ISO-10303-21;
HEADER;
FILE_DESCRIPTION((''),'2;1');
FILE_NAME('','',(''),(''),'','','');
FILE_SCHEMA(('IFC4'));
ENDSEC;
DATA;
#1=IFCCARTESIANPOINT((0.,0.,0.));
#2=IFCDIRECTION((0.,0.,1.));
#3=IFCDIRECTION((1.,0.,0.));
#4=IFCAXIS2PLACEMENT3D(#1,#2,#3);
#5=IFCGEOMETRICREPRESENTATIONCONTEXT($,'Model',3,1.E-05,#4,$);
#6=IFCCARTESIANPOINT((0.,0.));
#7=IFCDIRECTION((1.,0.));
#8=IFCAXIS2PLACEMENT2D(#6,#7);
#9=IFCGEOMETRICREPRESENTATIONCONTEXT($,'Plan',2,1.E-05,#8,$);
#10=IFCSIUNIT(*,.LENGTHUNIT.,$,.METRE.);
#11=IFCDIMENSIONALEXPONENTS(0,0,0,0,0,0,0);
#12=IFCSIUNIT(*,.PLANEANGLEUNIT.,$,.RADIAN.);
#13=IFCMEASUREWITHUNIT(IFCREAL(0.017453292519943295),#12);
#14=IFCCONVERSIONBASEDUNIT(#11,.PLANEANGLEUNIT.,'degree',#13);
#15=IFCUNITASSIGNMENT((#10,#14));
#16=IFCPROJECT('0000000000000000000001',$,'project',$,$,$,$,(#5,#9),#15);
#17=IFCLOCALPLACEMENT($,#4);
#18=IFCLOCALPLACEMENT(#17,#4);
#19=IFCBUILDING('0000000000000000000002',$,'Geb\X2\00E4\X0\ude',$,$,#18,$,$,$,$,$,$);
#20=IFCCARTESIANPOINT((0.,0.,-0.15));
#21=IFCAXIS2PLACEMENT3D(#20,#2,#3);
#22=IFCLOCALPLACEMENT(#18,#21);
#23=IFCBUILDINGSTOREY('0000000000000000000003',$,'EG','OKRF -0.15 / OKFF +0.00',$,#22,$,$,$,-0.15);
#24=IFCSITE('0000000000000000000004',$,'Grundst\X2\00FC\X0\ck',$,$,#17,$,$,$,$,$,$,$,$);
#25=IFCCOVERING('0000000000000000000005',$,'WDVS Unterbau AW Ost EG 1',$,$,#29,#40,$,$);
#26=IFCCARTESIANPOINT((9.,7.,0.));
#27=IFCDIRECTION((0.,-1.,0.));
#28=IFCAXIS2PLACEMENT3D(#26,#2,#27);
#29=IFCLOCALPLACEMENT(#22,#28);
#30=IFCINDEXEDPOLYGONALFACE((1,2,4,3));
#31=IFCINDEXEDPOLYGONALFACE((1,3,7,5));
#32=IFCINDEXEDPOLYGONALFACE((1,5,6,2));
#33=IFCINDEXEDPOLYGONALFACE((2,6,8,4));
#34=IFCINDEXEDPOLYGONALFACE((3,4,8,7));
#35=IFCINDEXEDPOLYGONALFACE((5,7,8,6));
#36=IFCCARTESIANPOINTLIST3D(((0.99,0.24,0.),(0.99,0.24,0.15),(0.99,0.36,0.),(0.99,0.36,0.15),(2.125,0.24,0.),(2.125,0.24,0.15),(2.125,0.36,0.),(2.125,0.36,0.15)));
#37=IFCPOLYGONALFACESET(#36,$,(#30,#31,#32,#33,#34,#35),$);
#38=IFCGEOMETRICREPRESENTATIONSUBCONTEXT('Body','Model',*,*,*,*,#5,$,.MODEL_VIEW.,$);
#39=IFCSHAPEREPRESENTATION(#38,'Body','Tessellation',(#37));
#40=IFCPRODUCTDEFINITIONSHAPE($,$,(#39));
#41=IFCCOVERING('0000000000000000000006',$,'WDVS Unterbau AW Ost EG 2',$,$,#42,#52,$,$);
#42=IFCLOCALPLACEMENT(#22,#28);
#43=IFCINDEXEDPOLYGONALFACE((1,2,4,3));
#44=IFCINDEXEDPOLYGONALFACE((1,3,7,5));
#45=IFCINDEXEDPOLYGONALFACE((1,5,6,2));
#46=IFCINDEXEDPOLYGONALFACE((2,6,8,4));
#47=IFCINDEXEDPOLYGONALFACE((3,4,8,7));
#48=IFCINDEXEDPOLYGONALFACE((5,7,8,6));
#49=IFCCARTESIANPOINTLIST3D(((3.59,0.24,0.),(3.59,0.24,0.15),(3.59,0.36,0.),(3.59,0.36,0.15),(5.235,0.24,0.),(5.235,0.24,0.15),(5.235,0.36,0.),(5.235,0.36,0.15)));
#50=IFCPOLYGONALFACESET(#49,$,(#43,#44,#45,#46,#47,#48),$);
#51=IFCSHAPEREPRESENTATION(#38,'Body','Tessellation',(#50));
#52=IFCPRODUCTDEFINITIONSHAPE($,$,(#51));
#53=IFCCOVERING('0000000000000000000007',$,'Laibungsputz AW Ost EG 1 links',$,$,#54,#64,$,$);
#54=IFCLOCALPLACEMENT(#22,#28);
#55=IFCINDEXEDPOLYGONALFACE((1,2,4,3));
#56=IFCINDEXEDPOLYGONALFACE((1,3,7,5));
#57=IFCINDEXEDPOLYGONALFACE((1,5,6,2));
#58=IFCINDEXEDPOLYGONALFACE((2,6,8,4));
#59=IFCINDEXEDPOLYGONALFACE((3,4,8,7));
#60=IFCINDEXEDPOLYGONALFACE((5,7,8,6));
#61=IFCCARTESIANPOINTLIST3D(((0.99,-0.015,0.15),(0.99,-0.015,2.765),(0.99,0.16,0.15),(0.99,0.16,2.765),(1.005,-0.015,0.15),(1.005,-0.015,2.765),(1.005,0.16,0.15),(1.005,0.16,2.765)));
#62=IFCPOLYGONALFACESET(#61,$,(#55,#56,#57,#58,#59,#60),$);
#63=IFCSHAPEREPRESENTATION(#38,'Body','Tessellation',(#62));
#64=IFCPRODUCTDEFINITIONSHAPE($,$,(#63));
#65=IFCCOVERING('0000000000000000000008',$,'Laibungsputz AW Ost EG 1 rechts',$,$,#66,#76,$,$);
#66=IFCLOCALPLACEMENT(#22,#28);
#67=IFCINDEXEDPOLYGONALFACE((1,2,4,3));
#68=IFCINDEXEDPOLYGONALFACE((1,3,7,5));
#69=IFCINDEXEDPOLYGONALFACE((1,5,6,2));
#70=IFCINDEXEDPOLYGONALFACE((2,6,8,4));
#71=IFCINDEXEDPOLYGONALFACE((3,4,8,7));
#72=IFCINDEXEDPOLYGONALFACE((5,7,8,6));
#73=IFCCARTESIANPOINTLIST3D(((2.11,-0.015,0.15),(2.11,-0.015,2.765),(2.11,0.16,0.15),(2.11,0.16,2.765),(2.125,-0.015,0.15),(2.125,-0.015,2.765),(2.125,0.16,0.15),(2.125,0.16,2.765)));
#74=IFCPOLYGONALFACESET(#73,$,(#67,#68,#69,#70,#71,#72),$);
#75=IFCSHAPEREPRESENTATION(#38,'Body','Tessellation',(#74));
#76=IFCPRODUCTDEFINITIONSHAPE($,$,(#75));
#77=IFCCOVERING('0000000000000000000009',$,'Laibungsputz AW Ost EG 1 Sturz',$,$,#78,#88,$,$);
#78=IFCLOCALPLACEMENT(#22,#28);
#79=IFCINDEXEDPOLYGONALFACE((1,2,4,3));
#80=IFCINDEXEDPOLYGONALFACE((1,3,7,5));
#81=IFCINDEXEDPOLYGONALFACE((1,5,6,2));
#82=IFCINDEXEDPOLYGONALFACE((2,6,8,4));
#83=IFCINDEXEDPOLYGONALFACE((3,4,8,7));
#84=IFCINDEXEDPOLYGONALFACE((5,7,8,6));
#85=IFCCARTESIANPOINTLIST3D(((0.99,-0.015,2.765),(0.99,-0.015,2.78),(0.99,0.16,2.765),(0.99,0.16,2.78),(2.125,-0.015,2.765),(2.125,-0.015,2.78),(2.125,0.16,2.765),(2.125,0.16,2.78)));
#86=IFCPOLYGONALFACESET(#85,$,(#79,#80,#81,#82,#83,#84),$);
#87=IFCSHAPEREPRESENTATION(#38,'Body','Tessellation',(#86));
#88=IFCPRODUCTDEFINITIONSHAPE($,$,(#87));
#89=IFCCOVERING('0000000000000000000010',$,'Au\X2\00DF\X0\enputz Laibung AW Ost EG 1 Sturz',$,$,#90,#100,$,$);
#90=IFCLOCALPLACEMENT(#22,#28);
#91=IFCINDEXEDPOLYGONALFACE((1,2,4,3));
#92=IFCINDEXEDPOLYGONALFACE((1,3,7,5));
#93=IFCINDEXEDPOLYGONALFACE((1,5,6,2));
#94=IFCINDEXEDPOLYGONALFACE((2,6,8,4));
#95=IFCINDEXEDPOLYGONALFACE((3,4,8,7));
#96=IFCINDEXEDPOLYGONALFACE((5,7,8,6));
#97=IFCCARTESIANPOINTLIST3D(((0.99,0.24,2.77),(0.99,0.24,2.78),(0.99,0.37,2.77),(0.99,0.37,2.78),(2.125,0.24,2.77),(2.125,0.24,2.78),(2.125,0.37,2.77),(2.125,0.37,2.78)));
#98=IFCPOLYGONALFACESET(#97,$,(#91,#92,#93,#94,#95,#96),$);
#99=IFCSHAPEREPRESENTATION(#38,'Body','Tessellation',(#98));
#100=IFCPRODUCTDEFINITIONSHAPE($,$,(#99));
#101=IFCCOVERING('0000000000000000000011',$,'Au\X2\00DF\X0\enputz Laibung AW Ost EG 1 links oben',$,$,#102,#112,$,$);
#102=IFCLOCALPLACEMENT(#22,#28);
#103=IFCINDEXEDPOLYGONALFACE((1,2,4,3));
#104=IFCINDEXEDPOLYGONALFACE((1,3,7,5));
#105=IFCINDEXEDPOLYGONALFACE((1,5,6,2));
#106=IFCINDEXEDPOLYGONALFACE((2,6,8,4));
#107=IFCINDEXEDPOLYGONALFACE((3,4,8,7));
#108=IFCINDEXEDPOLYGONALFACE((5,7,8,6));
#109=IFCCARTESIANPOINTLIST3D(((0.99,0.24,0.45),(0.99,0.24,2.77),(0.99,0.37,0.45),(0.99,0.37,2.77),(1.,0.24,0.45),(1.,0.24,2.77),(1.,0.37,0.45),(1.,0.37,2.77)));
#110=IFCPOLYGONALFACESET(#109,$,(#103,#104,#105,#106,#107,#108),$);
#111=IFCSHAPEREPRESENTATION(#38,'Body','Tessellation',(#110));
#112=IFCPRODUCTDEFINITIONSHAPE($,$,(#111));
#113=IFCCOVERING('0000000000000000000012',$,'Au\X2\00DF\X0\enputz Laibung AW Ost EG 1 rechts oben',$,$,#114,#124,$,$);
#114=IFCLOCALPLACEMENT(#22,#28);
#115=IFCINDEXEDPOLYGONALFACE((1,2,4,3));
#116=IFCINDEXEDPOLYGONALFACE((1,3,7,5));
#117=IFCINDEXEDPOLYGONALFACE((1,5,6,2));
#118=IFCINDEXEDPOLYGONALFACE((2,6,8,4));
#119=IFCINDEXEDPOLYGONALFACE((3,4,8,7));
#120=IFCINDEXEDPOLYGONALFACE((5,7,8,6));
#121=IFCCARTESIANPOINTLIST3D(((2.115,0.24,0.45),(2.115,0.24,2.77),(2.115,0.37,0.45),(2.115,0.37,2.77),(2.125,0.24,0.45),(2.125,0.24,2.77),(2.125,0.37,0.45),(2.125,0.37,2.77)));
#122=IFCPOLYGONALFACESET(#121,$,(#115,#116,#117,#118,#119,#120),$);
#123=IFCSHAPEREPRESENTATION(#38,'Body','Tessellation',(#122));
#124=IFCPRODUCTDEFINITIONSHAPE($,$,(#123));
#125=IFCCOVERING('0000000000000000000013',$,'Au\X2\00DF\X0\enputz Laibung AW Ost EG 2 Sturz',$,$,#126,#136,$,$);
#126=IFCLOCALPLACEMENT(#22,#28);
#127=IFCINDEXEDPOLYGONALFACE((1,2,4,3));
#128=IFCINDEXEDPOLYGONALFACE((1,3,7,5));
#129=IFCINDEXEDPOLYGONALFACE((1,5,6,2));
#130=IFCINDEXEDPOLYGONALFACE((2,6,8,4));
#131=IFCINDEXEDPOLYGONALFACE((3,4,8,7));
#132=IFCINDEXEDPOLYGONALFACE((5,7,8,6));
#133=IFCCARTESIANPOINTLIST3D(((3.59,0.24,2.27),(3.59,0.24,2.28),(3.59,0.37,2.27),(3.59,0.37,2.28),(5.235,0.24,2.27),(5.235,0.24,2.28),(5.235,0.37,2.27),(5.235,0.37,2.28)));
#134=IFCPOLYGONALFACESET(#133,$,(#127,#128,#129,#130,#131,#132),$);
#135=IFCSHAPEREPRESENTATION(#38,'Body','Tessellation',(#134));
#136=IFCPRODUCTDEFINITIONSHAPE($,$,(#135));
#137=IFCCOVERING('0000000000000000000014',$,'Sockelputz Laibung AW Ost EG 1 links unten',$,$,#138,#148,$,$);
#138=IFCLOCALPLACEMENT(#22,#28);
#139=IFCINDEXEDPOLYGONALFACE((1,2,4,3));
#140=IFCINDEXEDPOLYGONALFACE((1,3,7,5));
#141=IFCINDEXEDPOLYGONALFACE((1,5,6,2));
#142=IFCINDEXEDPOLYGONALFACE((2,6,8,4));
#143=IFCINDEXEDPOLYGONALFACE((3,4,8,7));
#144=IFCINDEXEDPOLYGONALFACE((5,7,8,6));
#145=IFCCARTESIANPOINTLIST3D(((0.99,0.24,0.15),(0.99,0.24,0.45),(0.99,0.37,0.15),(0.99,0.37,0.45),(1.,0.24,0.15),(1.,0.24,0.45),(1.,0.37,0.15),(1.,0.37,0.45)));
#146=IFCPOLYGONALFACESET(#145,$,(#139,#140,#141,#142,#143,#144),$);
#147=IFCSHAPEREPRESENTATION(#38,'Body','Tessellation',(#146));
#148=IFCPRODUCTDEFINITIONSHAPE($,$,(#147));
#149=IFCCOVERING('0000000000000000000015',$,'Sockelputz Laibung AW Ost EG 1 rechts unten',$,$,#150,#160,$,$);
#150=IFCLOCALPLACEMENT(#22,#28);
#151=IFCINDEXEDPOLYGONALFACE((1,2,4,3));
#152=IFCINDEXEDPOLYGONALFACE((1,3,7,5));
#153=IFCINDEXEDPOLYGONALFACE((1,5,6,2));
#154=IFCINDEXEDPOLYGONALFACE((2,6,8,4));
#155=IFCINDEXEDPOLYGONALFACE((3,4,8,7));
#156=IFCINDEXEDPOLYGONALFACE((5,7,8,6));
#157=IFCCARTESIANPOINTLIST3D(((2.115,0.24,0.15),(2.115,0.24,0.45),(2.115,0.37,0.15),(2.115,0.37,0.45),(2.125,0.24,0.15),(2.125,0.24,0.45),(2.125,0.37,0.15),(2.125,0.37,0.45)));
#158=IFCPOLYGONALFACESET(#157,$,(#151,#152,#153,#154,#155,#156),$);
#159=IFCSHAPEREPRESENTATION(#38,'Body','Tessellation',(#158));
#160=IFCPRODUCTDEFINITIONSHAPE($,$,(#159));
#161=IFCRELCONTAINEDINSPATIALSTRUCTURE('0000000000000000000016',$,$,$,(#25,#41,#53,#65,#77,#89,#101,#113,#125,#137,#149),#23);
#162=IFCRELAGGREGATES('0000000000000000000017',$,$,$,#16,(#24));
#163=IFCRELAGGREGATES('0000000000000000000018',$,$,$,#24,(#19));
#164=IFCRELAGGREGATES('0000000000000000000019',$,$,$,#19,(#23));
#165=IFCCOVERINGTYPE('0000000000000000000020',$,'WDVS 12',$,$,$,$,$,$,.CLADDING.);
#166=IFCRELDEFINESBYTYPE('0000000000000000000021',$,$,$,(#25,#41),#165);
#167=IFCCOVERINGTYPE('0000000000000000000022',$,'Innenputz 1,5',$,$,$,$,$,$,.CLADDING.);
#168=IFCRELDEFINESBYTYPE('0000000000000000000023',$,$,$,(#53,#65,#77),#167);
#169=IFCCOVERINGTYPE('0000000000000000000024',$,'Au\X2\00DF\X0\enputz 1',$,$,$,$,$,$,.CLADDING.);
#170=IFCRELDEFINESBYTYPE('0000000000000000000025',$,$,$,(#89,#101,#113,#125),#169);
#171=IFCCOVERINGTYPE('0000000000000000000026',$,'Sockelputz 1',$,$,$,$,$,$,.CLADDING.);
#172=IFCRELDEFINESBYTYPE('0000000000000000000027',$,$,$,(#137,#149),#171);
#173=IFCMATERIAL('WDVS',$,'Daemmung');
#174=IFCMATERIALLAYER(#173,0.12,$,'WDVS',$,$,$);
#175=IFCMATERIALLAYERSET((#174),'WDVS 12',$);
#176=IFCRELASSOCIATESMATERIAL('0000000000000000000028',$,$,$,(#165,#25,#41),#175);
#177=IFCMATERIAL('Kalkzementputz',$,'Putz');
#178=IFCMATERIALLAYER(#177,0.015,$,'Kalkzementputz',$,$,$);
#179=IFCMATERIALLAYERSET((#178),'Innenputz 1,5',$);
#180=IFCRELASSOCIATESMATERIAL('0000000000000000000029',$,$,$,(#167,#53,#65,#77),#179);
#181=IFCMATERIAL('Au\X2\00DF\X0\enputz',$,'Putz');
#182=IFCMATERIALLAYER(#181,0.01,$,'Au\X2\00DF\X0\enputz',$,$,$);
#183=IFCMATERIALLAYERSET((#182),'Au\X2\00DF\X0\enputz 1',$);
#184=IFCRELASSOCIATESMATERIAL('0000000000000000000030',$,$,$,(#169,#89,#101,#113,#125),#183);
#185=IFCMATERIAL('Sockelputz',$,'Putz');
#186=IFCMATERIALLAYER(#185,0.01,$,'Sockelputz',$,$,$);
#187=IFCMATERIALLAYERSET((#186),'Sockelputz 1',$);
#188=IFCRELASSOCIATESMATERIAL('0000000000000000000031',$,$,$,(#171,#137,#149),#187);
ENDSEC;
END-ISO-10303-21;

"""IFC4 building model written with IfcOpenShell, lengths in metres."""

from ifc_helpers import new_model, entity, si_unit, converted_unit, frame, origin_with_axes, origin_2d_with_axis, place, context, subcontext, project, spatial, polyline, outline, extrude, material, layer, layer_set, layer_usage, type_object, element, save


model = new_model("IFC4")

# Units and contexts
model_context = context("Model", 3, precision=1e-05, world=origin_with_axes())
plan_context = context("Plan", 2, precision=1e-05, world=origin_2d_with_axis())
body_context_1 = subcontext(model_context, "Body", "Model", "MODEL_VIEW")
ifc_project = project(units=[si_unit("LENGTHUNIT", "METRE"), converted_unit("PLANEANGLEUNIT", "degree", entity("IfcReal", 0.017453292519943295), si_unit("PLANEANGLEUNIT", "RADIAN"), dimensions=[0, 0, 0, 0, 0, 0, 0])], contexts=[model_context, plan_context])

# Site, building, storey
site_placement = place(None, origin_with_axes())
site = spatial("IfcSite", under=ifc_project, at=site_placement, Name="Grundstück")
building_placement = place(site_placement, origin_with_axes())
building = spatial("IfcBuilding", under=site, at=building_placement, Name="Gebäude")
storey_placement = place(building_placement, frame((0.0, 0.0, -0.15), z_axis=(0.0, 0.0, 1.0), x_axis=(1.0, 0.0, 0.0)))
storey = spatial("IfcBuildingStorey", under=building, at=storey_placement, Name="EG", Description="OKRF -0.15 / OKFF +0.00", Elevation=-0.15)

# Shared definitions
ifc_material_1 = material(Name="WDVS", Category="Daemmung")

# Coverings
ifc_layer_1 = layer(ifc_material_1, 0.12, Name="WDVS")
ifc_layer_set_1 = layer_set([ifc_layer_1], Name="WDVS 12")
ifc_layer_usage_1 = layer_usage(ifc_layer_set_1, "AXIS2", "POSITIVE", 0.24)
covering_type_1 = type_object("IfcCoveringType", Name="WDVS 12", PredefinedType="CLADDING", material=ifc_layer_set_1)
covering_1_placement = place(storey_placement, frame((9.0, 7.0, 0.0), z_axis=(0.0, 0.0, 1.0), x_axis=(0.0, -1.0, 0.0)))
element("IfcCovering", 1, at=covering_1_placement, inside=storey, type_object=covering_type_1, material=ifc_layer_usage_1, Name="WDVS Unterbau AW Ost EG 1", context=body_context_1, shape_type="SweptSolid", body=[
    extrude(outline(polyline([(0.24, 0.0), (0.36, 0.0), (0.36, 0.15), (0.24, 0.15), (0.24, 0.0)])), frame((0.99, 0.0, 0.0), z_axis=(1.0, 0.0, 0.0), x_axis=(0.0, 1.0, 0.0)), (0.0, 0.0, 1.0), 1.135),
])
ifc_layer_usage_2 = layer_usage(ifc_layer_set_1, "AXIS2", "POSITIVE", 0.24)
covering_2_placement = place(storey_placement, frame((9.0, 7.0, 0.0), z_axis=(0.0, 0.0, 1.0), x_axis=(0.0, -1.0, 0.0)))
element("IfcCovering", 2, at=covering_2_placement, inside=storey, type_object=covering_type_1, material=ifc_layer_usage_2, Name="WDVS Unterbau AW Ost EG 2", context=body_context_1, shape_type="SweptSolid", body=[
    extrude(outline(polyline([(0.24, 0.0), (0.36, 0.0), (0.36, 0.15), (0.24, 0.15), (0.24, 0.0)])), frame((3.59, 0.0, 0.0), z_axis=(1.0, 0.0, 0.0), x_axis=(0.0, 1.0, 0.0)), (0.0, 0.0, 1.0), 1.645),
])
ifc_material_2 = material(Name="Kalkzementputz", Category="Putz")
ifc_layer_2 = layer(ifc_material_2, 0.015, Name="Kalkzementputz")
ifc_layer_set_2 = layer_set([ifc_layer_2], Name="Innenputz 1,5")
covering_type_2 = type_object("IfcCoveringType", Name="Innenputz 1,5", PredefinedType="CLADDING", material=ifc_layer_set_2)
ifc_layer_usage_3 = layer_usage(ifc_layer_set_2, "AXIS1", "POSITIVE", 0.99)
covering_3_placement = place(storey_placement, frame((9.0, 7.0, 0.0), z_axis=(0.0, 0.0, 1.0), x_axis=(0.0, -1.0, 0.0)))
element("IfcCovering", 3, at=covering_3_placement, inside=storey, type_object=covering_type_2, material=ifc_layer_usage_3, Name="Laibungsputz AW Ost EG 1 links", context=body_context_1, shape_type="SweptSolid", body=[
    extrude(outline(polyline([(-0.015, 0.15), (0.16, 0.15), (0.16, 2.765), (-0.015, 2.765), (-0.015, 0.15)])), frame((0.99, 0.0, 0.0), z_axis=(1.0, 0.0, 0.0), x_axis=(0.0, 1.0, 0.0)), (0.0, 0.0, 1.0), 0.015),
])
ifc_layer_usage_4 = layer_usage(ifc_layer_set_2, "AXIS1", "POSITIVE", 2.11)
covering_4_placement = place(storey_placement, frame((9.0, 7.0, 0.0), z_axis=(0.0, 0.0, 1.0), x_axis=(0.0, -1.0, 0.0)))
element("IfcCovering", 4, at=covering_4_placement, inside=storey, type_object=covering_type_2, material=ifc_layer_usage_4, Name="Laibungsputz AW Ost EG 1 rechts", context=body_context_1, shape_type="SweptSolid", body=[
    extrude(outline(polyline([(-0.015, 0.15), (0.16, 0.15), (0.16, 2.765), (-0.015, 2.765), (-0.015, 0.15)])), frame((2.11, 0.0, 0.0), z_axis=(1.0, 0.0, 0.0), x_axis=(0.0, 1.0, 0.0)), (0.0, 0.0, 1.0), 0.015),
])
ifc_layer_usage_5 = layer_usage(ifc_layer_set_2, "AXIS3", "POSITIVE", 2.765)
covering_5_placement = place(storey_placement, frame((9.0, 7.0, 0.0), z_axis=(0.0, 0.0, 1.0), x_axis=(0.0, -1.0, 0.0)))
element("IfcCovering", 5, at=covering_5_placement, inside=storey, type_object=covering_type_2, material=ifc_layer_usage_5, Name="Laibungsputz AW Ost EG 1 Sturz", context=body_context_1, shape_type="SweptSolid", body=[
    extrude(outline(polyline([(-0.015, 2.765), (0.16, 2.765), (0.16, 2.78), (-0.015, 2.78), (-0.015, 2.765)])), frame((0.99, 0.0, 0.0), z_axis=(1.0, 0.0, 0.0), x_axis=(0.0, 1.0, 0.0)), (0.0, 0.0, 1.0), 1.135),
])
ifc_material_3 = material(Name="Außenputz", Category="Putz")
ifc_layer_3 = layer(ifc_material_3, 0.01, Name="Außenputz")
ifc_layer_set_3 = layer_set([ifc_layer_3], Name="Außenputz 1")
covering_type_3 = type_object("IfcCoveringType", Name="Außenputz 1", PredefinedType="CLADDING", material=ifc_layer_set_3)
ifc_layer_usage_6 = layer_usage(ifc_layer_set_3, "AXIS3", "POSITIVE", 2.77)
covering_6_placement = place(storey_placement, frame((9.0, 7.0, 0.0), z_axis=(0.0, 0.0, 1.0), x_axis=(0.0, -1.0, 0.0)))
element("IfcCovering", 6, at=covering_6_placement, inside=storey, type_object=covering_type_3, material=ifc_layer_usage_6, Name="Außenputz Laibung AW Ost EG 1 Sturz", context=body_context_1, shape_type="SweptSolid", body=[
    extrude(outline(polyline([(0.24, 2.77), (0.37, 2.77), (0.37, 2.78), (0.24, 2.78), (0.24, 2.77)])), frame((0.99, 0.0, 0.0), z_axis=(1.0, 0.0, 0.0), x_axis=(0.0, 1.0, 0.0)), (0.0, 0.0, 1.0), 1.135),
])
ifc_layer_usage_7 = layer_usage(ifc_layer_set_3, "AXIS1", "POSITIVE", 0.99)
covering_7_placement = place(storey_placement, frame((9.0, 7.0, 0.0), z_axis=(0.0, 0.0, 1.0), x_axis=(0.0, -1.0, 0.0)))
element("IfcCovering", 7, at=covering_7_placement, inside=storey, type_object=covering_type_3, material=ifc_layer_usage_7, Name="Außenputz Laibung AW Ost EG 1 links oben", context=body_context_1, shape_type="SweptSolid", body=[
    extrude(outline(polyline([(0.24, 0.45), (0.37, 0.45), (0.37, 2.77), (0.24, 2.77), (0.24, 0.45)])), frame((0.99, 0.0, 0.0), z_axis=(1.0, 0.0, 0.0), x_axis=(0.0, 1.0, 0.0)), (0.0, 0.0, 1.0), 0.01),
])
ifc_layer_usage_8 = layer_usage(ifc_layer_set_3, "AXIS1", "POSITIVE", 2.115)
covering_8_placement = place(storey_placement, frame((9.0, 7.0, 0.0), z_axis=(0.0, 0.0, 1.0), x_axis=(0.0, -1.0, 0.0)))
element("IfcCovering", 8, at=covering_8_placement, inside=storey, type_object=covering_type_3, material=ifc_layer_usage_8, Name="Außenputz Laibung AW Ost EG 1 rechts oben", context=body_context_1, shape_type="SweptSolid", body=[
    extrude(outline(polyline([(0.24, 0.45), (0.37, 0.45), (0.37, 2.77), (0.24, 2.77), (0.24, 0.45)])), frame((2.115, 0.0, 0.0), z_axis=(1.0, 0.0, 0.0), x_axis=(0.0, 1.0, 0.0)), (0.0, 0.0, 1.0), 0.01),
])
ifc_layer_usage_9 = layer_usage(ifc_layer_set_3, "AXIS3", "POSITIVE", 2.27)
covering_9_placement = place(storey_placement, frame((9.0, 7.0, 0.0), z_axis=(0.0, 0.0, 1.0), x_axis=(0.0, -1.0, 0.0)))
element("IfcCovering", 9, at=covering_9_placement, inside=storey, type_object=covering_type_3, material=ifc_layer_usage_9, Name="Außenputz Laibung AW Ost EG 2 Sturz", context=body_context_1, shape_type="SweptSolid", body=[
    extrude(outline(polyline([(0.24, 2.27), (0.37, 2.27), (0.37, 2.28), (0.24, 2.28), (0.24, 2.27)])), frame((3.59, 0.0, 0.0), z_axis=(1.0, 0.0, 0.0), x_axis=(0.0, 1.0, 0.0)), (0.0, 0.0, 1.0), 1.645),
])
ifc_material_4 = material(Name="Sockelputz", Category="Putz")
ifc_layer_4 = layer(ifc_material_4, 0.01, Name="Sockelputz")
ifc_layer_set_4 = layer_set([ifc_layer_4], Name="Sockelputz 1")
ifc_layer_usage_10 = layer_usage(ifc_layer_set_4, "AXIS1", "POSITIVE", 0.99)
covering_type_4 = type_object("IfcCoveringType", Name="Sockelputz 1", PredefinedType="CLADDING", material=ifc_layer_set_4)
covering_10_placement = place(storey_placement, frame((9.0, 7.0, 0.0), z_axis=(0.0, 0.0, 1.0), x_axis=(0.0, -1.0, 0.0)))
element("IfcCovering", 10, at=covering_10_placement, inside=storey, type_object=covering_type_4, material=ifc_layer_usage_10, Name="Sockelputz Laibung AW Ost EG 1 links unten", context=body_context_1, shape_type="SweptSolid", body=[
    extrude(outline(polyline([(0.24, 0.15), (0.37, 0.15), (0.37, 0.45), (0.24, 0.45), (0.24, 0.15)])), frame((0.99, 0.0, 0.0), z_axis=(1.0, 0.0, 0.0), x_axis=(0.0, 1.0, 0.0)), (0.0, 0.0, 1.0), 0.01),
])
ifc_layer_usage_11 = layer_usage(ifc_layer_set_4, "AXIS1", "POSITIVE", 2.115)
covering_11_placement = place(storey_placement, frame((9.0, 7.0, 0.0), z_axis=(0.0, 0.0, 1.0), x_axis=(0.0, -1.0, 0.0)))
element("IfcCovering", 11, at=covering_11_placement, inside=storey, type_object=covering_type_4, material=ifc_layer_usage_11, Name="Sockelputz Laibung AW Ost EG 1 rechts unten", context=body_context_1, shape_type="SweptSolid", body=[
    extrude(outline(polyline([(0.24, 0.15), (0.37, 0.15), (0.37, 0.45), (0.24, 0.45), (0.24, 0.15)])), frame((2.115, 0.0, 0.0), z_axis=(1.0, 0.0, 0.0), x_axis=(0.0, 1.0, 0.0)), (0.0, 0.0, 1.0), 0.01),
])

save(model, "model.ifc")
